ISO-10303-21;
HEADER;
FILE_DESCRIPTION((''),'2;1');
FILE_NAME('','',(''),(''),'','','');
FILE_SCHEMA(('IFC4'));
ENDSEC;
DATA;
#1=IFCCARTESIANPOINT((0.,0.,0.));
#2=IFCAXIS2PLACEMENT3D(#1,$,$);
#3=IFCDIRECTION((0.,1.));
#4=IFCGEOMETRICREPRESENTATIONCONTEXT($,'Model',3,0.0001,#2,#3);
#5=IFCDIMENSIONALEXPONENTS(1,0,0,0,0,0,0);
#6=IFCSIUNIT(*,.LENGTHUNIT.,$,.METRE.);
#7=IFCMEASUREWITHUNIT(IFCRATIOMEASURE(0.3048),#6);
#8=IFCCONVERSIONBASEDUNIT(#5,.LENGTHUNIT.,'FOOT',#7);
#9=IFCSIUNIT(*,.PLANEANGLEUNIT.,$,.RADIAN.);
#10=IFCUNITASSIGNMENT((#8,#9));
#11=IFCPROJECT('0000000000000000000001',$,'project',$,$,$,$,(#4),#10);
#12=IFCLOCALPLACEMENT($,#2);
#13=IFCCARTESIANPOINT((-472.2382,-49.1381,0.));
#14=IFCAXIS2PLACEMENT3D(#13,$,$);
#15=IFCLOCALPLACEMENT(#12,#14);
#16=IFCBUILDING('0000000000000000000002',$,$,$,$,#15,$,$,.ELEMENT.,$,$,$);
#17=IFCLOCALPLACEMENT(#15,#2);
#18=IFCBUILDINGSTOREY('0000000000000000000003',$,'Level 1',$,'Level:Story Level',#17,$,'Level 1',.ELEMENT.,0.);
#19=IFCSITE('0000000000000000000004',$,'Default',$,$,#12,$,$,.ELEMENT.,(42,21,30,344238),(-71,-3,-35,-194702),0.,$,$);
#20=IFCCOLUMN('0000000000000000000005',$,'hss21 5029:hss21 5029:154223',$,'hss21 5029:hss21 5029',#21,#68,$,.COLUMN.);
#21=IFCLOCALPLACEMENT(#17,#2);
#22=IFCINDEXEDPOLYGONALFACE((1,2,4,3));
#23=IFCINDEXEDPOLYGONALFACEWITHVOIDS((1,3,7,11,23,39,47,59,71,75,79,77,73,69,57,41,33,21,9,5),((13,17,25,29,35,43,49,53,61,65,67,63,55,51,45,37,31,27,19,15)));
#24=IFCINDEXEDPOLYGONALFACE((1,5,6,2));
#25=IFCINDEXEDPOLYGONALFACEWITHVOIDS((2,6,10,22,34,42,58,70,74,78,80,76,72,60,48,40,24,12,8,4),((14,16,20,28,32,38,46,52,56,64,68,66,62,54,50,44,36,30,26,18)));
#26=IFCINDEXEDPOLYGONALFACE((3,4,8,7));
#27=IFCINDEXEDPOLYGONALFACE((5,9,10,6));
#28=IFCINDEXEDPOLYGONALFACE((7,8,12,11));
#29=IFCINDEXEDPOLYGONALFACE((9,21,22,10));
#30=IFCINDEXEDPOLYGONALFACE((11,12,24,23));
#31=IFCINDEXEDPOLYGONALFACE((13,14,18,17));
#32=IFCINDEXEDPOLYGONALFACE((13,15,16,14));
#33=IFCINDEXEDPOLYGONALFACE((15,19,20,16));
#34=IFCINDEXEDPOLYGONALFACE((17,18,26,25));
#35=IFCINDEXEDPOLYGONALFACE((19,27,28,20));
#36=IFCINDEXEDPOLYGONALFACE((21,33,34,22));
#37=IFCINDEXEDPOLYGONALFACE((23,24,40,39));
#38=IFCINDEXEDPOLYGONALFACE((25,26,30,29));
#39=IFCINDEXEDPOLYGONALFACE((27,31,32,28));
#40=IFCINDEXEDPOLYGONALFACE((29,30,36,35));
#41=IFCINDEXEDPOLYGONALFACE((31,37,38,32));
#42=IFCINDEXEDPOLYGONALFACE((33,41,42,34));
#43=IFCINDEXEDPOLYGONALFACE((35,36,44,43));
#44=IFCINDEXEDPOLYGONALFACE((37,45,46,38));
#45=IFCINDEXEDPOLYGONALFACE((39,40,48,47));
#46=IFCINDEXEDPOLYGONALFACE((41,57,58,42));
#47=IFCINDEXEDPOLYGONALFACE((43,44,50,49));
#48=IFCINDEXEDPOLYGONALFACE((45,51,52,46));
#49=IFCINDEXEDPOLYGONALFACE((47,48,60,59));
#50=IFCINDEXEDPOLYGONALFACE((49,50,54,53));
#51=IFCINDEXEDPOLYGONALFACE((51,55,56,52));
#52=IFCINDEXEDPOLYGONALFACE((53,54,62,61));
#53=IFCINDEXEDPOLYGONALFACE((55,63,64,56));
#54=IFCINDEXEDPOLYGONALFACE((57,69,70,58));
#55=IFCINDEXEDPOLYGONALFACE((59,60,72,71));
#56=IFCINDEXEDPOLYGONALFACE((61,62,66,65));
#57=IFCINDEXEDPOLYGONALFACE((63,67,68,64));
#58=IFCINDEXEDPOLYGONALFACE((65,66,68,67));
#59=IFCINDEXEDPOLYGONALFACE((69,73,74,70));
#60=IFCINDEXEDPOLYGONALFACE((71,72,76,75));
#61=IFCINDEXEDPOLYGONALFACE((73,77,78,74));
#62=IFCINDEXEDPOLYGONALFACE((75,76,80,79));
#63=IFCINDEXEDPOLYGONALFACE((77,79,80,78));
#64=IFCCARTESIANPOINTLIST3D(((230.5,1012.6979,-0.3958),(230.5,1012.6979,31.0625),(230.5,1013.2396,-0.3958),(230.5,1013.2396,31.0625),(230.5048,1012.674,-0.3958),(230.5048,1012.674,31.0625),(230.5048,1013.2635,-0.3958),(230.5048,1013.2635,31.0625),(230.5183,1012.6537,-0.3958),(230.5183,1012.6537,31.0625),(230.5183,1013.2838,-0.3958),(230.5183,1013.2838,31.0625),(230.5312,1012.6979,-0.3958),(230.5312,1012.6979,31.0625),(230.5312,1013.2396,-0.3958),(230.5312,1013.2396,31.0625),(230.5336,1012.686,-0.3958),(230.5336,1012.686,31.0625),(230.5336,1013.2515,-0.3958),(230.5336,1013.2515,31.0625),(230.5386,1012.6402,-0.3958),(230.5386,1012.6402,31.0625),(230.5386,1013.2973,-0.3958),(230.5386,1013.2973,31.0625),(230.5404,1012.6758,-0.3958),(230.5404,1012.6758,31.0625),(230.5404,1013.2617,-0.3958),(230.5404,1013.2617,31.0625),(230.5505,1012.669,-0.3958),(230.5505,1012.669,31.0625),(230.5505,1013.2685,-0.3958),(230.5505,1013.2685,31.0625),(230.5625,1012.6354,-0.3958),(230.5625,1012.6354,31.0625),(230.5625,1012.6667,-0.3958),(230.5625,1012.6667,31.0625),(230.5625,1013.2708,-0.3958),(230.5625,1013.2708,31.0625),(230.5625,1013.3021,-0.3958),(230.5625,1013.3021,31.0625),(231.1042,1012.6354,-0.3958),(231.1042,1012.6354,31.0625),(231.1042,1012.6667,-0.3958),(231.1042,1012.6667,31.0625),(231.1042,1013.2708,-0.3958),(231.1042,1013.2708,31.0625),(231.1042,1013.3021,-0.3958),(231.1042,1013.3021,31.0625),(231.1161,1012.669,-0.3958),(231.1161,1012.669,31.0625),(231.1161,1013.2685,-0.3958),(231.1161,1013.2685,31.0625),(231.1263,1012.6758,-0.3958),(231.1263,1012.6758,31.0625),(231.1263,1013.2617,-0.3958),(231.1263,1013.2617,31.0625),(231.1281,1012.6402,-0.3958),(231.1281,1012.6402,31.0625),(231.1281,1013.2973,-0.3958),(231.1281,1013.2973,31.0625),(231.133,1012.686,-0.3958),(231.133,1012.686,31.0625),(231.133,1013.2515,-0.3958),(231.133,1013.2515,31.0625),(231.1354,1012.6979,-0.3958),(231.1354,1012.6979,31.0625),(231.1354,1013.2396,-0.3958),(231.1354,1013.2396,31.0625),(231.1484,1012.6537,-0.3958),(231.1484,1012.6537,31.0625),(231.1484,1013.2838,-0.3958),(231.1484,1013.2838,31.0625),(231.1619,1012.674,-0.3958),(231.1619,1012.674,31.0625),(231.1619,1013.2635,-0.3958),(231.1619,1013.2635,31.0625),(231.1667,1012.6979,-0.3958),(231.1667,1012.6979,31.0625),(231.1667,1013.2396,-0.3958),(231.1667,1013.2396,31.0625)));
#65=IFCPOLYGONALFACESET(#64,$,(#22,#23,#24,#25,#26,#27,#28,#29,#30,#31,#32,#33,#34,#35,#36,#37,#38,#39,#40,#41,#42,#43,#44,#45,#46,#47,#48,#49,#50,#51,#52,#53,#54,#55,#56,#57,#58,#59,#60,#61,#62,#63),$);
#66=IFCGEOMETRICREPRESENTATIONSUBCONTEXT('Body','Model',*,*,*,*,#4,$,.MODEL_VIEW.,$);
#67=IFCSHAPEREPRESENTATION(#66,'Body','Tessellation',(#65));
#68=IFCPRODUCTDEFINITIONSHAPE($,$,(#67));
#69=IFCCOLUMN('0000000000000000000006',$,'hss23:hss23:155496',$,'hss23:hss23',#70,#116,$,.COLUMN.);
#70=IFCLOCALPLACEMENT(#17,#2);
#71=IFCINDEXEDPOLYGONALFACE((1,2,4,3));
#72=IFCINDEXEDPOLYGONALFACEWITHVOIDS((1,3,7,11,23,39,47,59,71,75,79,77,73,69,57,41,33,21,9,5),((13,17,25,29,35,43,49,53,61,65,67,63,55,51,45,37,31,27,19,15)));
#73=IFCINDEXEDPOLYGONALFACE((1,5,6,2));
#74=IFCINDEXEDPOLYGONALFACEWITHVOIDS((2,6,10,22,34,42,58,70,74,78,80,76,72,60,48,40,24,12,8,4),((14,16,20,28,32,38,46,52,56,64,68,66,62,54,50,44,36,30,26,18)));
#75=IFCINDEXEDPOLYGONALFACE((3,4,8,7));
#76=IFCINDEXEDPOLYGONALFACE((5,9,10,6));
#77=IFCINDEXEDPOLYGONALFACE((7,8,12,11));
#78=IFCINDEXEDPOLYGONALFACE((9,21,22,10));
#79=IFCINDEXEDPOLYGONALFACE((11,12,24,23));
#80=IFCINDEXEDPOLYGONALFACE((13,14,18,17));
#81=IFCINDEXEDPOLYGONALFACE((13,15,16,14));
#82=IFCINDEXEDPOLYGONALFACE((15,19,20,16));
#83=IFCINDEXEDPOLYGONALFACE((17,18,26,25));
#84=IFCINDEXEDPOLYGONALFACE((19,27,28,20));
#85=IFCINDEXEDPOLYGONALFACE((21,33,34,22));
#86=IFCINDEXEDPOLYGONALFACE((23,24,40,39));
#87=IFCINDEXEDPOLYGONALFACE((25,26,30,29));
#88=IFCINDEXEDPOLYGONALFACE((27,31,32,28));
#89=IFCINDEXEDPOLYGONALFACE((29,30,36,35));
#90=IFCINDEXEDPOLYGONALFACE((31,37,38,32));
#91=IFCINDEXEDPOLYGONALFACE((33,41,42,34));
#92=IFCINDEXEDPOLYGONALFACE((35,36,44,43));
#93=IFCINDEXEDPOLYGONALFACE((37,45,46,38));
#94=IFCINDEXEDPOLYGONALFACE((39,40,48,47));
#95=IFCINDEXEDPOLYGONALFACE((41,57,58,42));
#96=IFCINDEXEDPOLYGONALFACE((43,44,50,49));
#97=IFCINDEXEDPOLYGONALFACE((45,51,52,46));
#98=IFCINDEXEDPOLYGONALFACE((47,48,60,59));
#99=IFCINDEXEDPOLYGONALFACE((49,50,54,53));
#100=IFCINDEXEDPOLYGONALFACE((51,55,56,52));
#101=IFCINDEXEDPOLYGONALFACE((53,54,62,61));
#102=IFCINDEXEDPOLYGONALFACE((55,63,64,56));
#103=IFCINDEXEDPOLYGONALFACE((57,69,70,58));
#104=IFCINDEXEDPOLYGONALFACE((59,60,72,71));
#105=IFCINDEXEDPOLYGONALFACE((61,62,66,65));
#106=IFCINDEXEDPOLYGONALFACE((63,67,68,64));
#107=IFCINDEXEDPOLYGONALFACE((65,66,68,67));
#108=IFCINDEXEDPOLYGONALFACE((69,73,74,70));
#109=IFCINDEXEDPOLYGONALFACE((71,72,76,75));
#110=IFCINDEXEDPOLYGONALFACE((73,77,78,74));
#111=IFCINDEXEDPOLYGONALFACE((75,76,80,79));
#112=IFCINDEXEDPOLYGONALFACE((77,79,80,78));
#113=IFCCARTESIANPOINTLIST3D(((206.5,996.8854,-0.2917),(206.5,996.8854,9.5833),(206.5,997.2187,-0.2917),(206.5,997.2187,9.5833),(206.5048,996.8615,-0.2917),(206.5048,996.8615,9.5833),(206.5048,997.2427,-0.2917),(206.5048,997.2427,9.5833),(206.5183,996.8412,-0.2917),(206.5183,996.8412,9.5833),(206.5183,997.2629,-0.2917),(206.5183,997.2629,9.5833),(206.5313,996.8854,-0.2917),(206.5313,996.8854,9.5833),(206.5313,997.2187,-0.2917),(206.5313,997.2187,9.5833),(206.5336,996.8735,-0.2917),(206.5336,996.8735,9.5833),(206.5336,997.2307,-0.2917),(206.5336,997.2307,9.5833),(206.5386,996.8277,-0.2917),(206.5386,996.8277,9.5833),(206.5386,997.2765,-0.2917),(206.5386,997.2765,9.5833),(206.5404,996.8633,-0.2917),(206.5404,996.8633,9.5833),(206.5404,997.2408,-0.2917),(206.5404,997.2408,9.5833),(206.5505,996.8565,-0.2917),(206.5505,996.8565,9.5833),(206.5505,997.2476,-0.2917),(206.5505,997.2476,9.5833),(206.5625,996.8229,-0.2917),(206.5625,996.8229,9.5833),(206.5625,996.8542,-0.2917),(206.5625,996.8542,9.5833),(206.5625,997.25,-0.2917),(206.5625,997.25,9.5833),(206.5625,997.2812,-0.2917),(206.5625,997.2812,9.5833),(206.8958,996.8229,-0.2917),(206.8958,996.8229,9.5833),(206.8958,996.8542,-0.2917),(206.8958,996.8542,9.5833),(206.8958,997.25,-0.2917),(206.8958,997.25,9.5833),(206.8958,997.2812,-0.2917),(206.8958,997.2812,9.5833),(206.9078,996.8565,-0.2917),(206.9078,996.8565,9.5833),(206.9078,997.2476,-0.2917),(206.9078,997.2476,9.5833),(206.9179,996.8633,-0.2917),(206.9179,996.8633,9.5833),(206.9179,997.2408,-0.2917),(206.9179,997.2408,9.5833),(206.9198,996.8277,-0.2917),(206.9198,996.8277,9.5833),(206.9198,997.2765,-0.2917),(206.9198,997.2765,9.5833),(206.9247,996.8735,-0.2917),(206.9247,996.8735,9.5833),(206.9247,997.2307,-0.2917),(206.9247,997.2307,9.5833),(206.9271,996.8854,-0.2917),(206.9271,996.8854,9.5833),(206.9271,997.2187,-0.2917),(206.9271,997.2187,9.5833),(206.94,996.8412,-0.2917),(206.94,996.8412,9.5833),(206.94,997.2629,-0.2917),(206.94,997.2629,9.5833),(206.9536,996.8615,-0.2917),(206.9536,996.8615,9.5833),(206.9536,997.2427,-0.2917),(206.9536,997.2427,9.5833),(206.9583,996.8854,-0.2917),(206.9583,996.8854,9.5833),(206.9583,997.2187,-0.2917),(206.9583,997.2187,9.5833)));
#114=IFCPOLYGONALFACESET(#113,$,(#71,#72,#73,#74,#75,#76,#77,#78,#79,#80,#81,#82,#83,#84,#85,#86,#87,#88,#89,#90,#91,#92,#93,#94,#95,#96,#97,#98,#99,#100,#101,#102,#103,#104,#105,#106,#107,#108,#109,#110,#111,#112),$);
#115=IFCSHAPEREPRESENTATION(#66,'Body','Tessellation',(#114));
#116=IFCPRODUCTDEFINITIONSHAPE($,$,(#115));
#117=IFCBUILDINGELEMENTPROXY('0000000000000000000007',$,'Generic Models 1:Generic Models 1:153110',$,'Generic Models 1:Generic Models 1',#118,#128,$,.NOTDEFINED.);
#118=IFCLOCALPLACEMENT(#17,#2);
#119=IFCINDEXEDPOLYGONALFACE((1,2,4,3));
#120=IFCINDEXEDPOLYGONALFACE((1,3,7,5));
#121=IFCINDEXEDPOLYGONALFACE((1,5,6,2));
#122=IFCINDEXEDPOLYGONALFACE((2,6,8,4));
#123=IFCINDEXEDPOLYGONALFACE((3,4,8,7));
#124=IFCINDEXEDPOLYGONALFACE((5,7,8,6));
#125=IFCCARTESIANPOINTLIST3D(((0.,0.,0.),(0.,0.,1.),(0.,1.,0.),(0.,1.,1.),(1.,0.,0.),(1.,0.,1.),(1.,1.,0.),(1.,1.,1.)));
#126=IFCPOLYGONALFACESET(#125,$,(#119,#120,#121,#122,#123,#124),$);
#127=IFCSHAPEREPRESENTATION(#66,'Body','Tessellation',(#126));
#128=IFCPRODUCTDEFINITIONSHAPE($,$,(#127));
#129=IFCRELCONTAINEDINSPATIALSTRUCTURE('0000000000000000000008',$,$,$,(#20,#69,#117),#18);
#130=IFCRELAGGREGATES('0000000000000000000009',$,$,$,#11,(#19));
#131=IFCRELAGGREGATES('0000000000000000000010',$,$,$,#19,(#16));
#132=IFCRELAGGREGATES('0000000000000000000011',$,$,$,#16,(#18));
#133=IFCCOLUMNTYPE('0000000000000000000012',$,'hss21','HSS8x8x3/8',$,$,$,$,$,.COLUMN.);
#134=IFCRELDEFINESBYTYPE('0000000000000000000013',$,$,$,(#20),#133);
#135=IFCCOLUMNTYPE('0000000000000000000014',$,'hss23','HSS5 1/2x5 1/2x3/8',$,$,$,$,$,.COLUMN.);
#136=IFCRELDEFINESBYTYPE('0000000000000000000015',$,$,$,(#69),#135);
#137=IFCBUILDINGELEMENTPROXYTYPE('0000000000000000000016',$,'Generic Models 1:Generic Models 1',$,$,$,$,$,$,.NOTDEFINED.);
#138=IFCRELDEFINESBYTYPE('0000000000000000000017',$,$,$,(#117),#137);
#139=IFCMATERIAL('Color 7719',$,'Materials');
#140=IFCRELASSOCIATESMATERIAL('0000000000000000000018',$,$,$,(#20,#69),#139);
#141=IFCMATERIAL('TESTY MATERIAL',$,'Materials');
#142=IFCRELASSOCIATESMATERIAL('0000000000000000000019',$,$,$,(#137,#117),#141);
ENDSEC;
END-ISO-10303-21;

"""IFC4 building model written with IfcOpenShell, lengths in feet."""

from ifc_helpers import new_model, entity, si_unit, converted_unit, direction, frame, origin, origin_2d_with_axis, place, context, subcontext, project, spatial, polyline, rectangle, outline, extrude, boolean, source, transform, mapped, material, type_object, type_shapes, element, save


model = new_model("IFC4")

# Units and contexts
model_context = context("Model", 3, precision=0.0001, world=origin(), true_north=direction((0.0, 1.0)))
body_context = subcontext(model_context, "Body", "Model", "MODEL_VIEW")
ifc_project = project(units=[converted_unit("LENGTHUNIT", "FOOT", entity("IfcRatioMeasure", 0.3048), si_unit("LENGTHUNIT", "METRE"), dimensions=[1, 0, 0, 0, 0, 0, 0]), si_unit("PLANEANGLEUNIT", "RADIAN")], contexts=[model_context])

# Site, building, storey
site_placement = place(None, origin())
site = spatial("IfcSite", under=ifc_project, at=site_placement, Name="Default", CompositionType="ELEMENT", RefLatitude=(42, 21, 30, 344238), RefLongitude=(-71, -3, -35, -194702), RefElevation=0.0)
building_placement = place(site_placement, frame((-472.2382, -49.1381, 0.0)))
building = spatial("IfcBuilding", under=site, at=building_placement, CompositionType="ELEMENT")
storey_placement = place(building_placement, origin())
storey = spatial("IfcBuildingStorey", under=building, at=storey_placement, Name="Level 1", ObjectType="Level:Story Level", LongName="Level 1", CompositionType="ELEMENT", Elevation=0.0)

# Columns
ifc_material_1 = material(Name="Color 7719", Category="Materials")
column_type_1 = type_object("IfcColumnType", Name="hss21", Description="HSS8x8x3/8", PredefinedType="COLUMN")
shared_shape_1 = source(origin(), body_context, "Body", "CSG", [
    boolean("DIFFERENCE", extrude(outline(polyline([(-0.2708, -0.3333), (0.2708, -0.3333), (0.2948, -0.3286), (0.315, -0.315), (0.3286, -0.2948), (0.3333, -0.2708), (0.3333, 0.2708), (0.3286, 0.2948), (0.315, 0.315), (0.2948, 0.3286), (0.2708, 0.3333), (-0.2708, 0.3333), (-0.2948, 0.3286), (-0.315, 0.315), (-0.3286, 0.2948), (-0.3333, 0.2708), (-0.3333, -0.2708), (-0.3286, -0.2948), (-0.315, -0.315), (-0.2948, -0.3286), (-0.2708, -0.3333)])), frame((230.8333, 1012.9688, -0.3958), z_axis=(0.0, 0.0, 1.0), x_axis=(0.0, -1.0, 0.0)), (0.0, 0.0, 1.0), 31.4583), extrude(outline(polyline([(-0.2708, -0.3021), (0.2708, -0.3021), (0.2828, -0.2997), (0.2929, -0.2929), (0.2997, -0.2828), (0.3021, -0.2708), (0.3021, 0.2708), (0.2997, 0.2828), (0.2929, 0.2929), (0.2828, 0.2997), (0.2708, 0.3021), (-0.2708, 0.3021), (-0.2828, 0.2997), (-0.2929, 0.2929), (-0.2997, 0.2828), (-0.3021, 0.2708), (-0.3021, -0.2708), (-0.2997, -0.2828), (-0.2929, -0.2929), (-0.2828, -0.2997), (-0.2708, -0.3021)])), frame((230.8333, 1012.9688, 31.0625), z_axis=(0.0, 0.0, -1.0), x_axis=(0.0, -1.0, 0.0)), (0.0, 0.0, 1.0), 31.4583)),
])
type_shapes(column_type_1, [shared_shape_1])
column_1_placement = place(building_placement, origin())
element("IfcColumn", 1, at=column_1_placement, inside=storey, type_object=column_type_1, material=ifc_material_1, Name="hss21 5029:hss21 5029:154223", ObjectType="hss21 5029:hss21 5029", PredefinedType="COLUMN", context=body_context, shape_type="MappedRepresentation", body=[
    mapped(shared_shape_1, transform((0.0, 0.0, 0.0), scale=1.0)),
])
column_type_2 = type_object("IfcColumnType", Name="hss23", Description="HSS5 1/2x5 1/2x3/8", PredefinedType="COLUMN")
shared_shape_2 = source(origin(), body_context, "Body", "CSG", [
    boolean("DIFFERENCE", extrude(outline(polyline([(-0.1667, -0.2292), (0.1667, -0.2292), (0.1906, -0.2244), (0.2109, -0.2109), (0.2244, -0.1906), (0.2292, -0.1667), (0.2292, 0.1667), (0.2244, 0.1906), (0.2109, 0.2109), (0.1906, 0.2244), (0.1667, 0.2292), (-0.1667, 0.2292), (-0.1906, 0.2244), (-0.2109, 0.2109), (-0.2244, 0.1906), (-0.2292, 0.1667), (-0.2292, -0.1667), (-0.2244, -0.1906), (-0.2109, -0.2109), (-0.1906, -0.2244), (-0.1667, -0.2292)])), frame((206.7292, 997.0521, -0.2917), z_axis=(0.0, 0.0, 1.0), x_axis=(0.0, -1.0, 0.0)), (0.0, 0.0, 1.0), 9.875), extrude(outline(polyline([(-0.1667, -0.1979), (0.1667, -0.1979), (0.1786, -0.1955), (0.1888, -0.1888), (0.1955, -0.1786), (0.1979, -0.1667), (0.1979, 0.1667), (0.1955, 0.1786), (0.1888, 0.1888), (0.1786, 0.1955), (0.1667, 0.1979), (-0.1667, 0.1979), (-0.1786, 0.1955), (-0.1888, 0.1888), (-0.1955, 0.1786), (-0.1979, 0.1667), (-0.1979, -0.1667), (-0.1955, -0.1786), (-0.1888, -0.1888), (-0.1786, -0.1955), (-0.1667, -0.1979)])), frame((206.7292, 997.0521, 9.5833), z_axis=(0.0, 0.0, -1.0), x_axis=(0.0, -1.0, 0.0)), (0.0, 0.0, 1.0), 9.875)),
])
type_shapes(column_type_2, [shared_shape_2])
column_2_placement = place(building_placement, origin())
element("IfcColumn", 2, at=column_2_placement, inside=storey, type_object=column_type_2, material=ifc_material_1, Name="hss23:hss23:155496", ObjectType="hss23:hss23", PredefinedType="COLUMN", context=body_context, shape_type="MappedRepresentation", body=[
    mapped(shared_shape_2, transform((0.0, 0.0, 0.0), scale=1.0)),
])

# Building element proxy
ifc_material_2 = material(Name="TESTY MATERIAL", Category="Materials")
building_element_proxy_type_1 = type_object("IfcBuildingElementProxyType", Name="Generic Models 1:Generic Models 1", PredefinedType="NOTDEFINED", material=ifc_material_2)
shared_shape_3 = source(origin(), body_context, "Body", "SweptSolid", [
    extrude(rectangle(XDim=1.0, YDim=1.0, at=origin_2d_with_axis()), frame((0.5, 0.5, 0.0), z_axis=(0.0, 0.0, 1.0), x_axis=(0.0, 1.0, 0.0)), (0.0, 0.0, 1.0), 1.0),
])
type_shapes(building_element_proxy_type_1, [shared_shape_3])
proxy_1_placement = place(building_placement, origin())
element("IfcBuildingElementProxy", 3, at=proxy_1_placement, inside=storey, type_object=building_element_proxy_type_1, material=ifc_material_2, Name="Generic Models 1:Generic Models 1:153110", ObjectType="Generic Models 1:Generic Models 1", PredefinedType="NOTDEFINED", context=body_context, shape_type="MappedRepresentation", body=[
    mapped(shared_shape_3, transform((0.0, 0.0, 0.0), scale=1.0)),
])

save(model, "model.ifc")
